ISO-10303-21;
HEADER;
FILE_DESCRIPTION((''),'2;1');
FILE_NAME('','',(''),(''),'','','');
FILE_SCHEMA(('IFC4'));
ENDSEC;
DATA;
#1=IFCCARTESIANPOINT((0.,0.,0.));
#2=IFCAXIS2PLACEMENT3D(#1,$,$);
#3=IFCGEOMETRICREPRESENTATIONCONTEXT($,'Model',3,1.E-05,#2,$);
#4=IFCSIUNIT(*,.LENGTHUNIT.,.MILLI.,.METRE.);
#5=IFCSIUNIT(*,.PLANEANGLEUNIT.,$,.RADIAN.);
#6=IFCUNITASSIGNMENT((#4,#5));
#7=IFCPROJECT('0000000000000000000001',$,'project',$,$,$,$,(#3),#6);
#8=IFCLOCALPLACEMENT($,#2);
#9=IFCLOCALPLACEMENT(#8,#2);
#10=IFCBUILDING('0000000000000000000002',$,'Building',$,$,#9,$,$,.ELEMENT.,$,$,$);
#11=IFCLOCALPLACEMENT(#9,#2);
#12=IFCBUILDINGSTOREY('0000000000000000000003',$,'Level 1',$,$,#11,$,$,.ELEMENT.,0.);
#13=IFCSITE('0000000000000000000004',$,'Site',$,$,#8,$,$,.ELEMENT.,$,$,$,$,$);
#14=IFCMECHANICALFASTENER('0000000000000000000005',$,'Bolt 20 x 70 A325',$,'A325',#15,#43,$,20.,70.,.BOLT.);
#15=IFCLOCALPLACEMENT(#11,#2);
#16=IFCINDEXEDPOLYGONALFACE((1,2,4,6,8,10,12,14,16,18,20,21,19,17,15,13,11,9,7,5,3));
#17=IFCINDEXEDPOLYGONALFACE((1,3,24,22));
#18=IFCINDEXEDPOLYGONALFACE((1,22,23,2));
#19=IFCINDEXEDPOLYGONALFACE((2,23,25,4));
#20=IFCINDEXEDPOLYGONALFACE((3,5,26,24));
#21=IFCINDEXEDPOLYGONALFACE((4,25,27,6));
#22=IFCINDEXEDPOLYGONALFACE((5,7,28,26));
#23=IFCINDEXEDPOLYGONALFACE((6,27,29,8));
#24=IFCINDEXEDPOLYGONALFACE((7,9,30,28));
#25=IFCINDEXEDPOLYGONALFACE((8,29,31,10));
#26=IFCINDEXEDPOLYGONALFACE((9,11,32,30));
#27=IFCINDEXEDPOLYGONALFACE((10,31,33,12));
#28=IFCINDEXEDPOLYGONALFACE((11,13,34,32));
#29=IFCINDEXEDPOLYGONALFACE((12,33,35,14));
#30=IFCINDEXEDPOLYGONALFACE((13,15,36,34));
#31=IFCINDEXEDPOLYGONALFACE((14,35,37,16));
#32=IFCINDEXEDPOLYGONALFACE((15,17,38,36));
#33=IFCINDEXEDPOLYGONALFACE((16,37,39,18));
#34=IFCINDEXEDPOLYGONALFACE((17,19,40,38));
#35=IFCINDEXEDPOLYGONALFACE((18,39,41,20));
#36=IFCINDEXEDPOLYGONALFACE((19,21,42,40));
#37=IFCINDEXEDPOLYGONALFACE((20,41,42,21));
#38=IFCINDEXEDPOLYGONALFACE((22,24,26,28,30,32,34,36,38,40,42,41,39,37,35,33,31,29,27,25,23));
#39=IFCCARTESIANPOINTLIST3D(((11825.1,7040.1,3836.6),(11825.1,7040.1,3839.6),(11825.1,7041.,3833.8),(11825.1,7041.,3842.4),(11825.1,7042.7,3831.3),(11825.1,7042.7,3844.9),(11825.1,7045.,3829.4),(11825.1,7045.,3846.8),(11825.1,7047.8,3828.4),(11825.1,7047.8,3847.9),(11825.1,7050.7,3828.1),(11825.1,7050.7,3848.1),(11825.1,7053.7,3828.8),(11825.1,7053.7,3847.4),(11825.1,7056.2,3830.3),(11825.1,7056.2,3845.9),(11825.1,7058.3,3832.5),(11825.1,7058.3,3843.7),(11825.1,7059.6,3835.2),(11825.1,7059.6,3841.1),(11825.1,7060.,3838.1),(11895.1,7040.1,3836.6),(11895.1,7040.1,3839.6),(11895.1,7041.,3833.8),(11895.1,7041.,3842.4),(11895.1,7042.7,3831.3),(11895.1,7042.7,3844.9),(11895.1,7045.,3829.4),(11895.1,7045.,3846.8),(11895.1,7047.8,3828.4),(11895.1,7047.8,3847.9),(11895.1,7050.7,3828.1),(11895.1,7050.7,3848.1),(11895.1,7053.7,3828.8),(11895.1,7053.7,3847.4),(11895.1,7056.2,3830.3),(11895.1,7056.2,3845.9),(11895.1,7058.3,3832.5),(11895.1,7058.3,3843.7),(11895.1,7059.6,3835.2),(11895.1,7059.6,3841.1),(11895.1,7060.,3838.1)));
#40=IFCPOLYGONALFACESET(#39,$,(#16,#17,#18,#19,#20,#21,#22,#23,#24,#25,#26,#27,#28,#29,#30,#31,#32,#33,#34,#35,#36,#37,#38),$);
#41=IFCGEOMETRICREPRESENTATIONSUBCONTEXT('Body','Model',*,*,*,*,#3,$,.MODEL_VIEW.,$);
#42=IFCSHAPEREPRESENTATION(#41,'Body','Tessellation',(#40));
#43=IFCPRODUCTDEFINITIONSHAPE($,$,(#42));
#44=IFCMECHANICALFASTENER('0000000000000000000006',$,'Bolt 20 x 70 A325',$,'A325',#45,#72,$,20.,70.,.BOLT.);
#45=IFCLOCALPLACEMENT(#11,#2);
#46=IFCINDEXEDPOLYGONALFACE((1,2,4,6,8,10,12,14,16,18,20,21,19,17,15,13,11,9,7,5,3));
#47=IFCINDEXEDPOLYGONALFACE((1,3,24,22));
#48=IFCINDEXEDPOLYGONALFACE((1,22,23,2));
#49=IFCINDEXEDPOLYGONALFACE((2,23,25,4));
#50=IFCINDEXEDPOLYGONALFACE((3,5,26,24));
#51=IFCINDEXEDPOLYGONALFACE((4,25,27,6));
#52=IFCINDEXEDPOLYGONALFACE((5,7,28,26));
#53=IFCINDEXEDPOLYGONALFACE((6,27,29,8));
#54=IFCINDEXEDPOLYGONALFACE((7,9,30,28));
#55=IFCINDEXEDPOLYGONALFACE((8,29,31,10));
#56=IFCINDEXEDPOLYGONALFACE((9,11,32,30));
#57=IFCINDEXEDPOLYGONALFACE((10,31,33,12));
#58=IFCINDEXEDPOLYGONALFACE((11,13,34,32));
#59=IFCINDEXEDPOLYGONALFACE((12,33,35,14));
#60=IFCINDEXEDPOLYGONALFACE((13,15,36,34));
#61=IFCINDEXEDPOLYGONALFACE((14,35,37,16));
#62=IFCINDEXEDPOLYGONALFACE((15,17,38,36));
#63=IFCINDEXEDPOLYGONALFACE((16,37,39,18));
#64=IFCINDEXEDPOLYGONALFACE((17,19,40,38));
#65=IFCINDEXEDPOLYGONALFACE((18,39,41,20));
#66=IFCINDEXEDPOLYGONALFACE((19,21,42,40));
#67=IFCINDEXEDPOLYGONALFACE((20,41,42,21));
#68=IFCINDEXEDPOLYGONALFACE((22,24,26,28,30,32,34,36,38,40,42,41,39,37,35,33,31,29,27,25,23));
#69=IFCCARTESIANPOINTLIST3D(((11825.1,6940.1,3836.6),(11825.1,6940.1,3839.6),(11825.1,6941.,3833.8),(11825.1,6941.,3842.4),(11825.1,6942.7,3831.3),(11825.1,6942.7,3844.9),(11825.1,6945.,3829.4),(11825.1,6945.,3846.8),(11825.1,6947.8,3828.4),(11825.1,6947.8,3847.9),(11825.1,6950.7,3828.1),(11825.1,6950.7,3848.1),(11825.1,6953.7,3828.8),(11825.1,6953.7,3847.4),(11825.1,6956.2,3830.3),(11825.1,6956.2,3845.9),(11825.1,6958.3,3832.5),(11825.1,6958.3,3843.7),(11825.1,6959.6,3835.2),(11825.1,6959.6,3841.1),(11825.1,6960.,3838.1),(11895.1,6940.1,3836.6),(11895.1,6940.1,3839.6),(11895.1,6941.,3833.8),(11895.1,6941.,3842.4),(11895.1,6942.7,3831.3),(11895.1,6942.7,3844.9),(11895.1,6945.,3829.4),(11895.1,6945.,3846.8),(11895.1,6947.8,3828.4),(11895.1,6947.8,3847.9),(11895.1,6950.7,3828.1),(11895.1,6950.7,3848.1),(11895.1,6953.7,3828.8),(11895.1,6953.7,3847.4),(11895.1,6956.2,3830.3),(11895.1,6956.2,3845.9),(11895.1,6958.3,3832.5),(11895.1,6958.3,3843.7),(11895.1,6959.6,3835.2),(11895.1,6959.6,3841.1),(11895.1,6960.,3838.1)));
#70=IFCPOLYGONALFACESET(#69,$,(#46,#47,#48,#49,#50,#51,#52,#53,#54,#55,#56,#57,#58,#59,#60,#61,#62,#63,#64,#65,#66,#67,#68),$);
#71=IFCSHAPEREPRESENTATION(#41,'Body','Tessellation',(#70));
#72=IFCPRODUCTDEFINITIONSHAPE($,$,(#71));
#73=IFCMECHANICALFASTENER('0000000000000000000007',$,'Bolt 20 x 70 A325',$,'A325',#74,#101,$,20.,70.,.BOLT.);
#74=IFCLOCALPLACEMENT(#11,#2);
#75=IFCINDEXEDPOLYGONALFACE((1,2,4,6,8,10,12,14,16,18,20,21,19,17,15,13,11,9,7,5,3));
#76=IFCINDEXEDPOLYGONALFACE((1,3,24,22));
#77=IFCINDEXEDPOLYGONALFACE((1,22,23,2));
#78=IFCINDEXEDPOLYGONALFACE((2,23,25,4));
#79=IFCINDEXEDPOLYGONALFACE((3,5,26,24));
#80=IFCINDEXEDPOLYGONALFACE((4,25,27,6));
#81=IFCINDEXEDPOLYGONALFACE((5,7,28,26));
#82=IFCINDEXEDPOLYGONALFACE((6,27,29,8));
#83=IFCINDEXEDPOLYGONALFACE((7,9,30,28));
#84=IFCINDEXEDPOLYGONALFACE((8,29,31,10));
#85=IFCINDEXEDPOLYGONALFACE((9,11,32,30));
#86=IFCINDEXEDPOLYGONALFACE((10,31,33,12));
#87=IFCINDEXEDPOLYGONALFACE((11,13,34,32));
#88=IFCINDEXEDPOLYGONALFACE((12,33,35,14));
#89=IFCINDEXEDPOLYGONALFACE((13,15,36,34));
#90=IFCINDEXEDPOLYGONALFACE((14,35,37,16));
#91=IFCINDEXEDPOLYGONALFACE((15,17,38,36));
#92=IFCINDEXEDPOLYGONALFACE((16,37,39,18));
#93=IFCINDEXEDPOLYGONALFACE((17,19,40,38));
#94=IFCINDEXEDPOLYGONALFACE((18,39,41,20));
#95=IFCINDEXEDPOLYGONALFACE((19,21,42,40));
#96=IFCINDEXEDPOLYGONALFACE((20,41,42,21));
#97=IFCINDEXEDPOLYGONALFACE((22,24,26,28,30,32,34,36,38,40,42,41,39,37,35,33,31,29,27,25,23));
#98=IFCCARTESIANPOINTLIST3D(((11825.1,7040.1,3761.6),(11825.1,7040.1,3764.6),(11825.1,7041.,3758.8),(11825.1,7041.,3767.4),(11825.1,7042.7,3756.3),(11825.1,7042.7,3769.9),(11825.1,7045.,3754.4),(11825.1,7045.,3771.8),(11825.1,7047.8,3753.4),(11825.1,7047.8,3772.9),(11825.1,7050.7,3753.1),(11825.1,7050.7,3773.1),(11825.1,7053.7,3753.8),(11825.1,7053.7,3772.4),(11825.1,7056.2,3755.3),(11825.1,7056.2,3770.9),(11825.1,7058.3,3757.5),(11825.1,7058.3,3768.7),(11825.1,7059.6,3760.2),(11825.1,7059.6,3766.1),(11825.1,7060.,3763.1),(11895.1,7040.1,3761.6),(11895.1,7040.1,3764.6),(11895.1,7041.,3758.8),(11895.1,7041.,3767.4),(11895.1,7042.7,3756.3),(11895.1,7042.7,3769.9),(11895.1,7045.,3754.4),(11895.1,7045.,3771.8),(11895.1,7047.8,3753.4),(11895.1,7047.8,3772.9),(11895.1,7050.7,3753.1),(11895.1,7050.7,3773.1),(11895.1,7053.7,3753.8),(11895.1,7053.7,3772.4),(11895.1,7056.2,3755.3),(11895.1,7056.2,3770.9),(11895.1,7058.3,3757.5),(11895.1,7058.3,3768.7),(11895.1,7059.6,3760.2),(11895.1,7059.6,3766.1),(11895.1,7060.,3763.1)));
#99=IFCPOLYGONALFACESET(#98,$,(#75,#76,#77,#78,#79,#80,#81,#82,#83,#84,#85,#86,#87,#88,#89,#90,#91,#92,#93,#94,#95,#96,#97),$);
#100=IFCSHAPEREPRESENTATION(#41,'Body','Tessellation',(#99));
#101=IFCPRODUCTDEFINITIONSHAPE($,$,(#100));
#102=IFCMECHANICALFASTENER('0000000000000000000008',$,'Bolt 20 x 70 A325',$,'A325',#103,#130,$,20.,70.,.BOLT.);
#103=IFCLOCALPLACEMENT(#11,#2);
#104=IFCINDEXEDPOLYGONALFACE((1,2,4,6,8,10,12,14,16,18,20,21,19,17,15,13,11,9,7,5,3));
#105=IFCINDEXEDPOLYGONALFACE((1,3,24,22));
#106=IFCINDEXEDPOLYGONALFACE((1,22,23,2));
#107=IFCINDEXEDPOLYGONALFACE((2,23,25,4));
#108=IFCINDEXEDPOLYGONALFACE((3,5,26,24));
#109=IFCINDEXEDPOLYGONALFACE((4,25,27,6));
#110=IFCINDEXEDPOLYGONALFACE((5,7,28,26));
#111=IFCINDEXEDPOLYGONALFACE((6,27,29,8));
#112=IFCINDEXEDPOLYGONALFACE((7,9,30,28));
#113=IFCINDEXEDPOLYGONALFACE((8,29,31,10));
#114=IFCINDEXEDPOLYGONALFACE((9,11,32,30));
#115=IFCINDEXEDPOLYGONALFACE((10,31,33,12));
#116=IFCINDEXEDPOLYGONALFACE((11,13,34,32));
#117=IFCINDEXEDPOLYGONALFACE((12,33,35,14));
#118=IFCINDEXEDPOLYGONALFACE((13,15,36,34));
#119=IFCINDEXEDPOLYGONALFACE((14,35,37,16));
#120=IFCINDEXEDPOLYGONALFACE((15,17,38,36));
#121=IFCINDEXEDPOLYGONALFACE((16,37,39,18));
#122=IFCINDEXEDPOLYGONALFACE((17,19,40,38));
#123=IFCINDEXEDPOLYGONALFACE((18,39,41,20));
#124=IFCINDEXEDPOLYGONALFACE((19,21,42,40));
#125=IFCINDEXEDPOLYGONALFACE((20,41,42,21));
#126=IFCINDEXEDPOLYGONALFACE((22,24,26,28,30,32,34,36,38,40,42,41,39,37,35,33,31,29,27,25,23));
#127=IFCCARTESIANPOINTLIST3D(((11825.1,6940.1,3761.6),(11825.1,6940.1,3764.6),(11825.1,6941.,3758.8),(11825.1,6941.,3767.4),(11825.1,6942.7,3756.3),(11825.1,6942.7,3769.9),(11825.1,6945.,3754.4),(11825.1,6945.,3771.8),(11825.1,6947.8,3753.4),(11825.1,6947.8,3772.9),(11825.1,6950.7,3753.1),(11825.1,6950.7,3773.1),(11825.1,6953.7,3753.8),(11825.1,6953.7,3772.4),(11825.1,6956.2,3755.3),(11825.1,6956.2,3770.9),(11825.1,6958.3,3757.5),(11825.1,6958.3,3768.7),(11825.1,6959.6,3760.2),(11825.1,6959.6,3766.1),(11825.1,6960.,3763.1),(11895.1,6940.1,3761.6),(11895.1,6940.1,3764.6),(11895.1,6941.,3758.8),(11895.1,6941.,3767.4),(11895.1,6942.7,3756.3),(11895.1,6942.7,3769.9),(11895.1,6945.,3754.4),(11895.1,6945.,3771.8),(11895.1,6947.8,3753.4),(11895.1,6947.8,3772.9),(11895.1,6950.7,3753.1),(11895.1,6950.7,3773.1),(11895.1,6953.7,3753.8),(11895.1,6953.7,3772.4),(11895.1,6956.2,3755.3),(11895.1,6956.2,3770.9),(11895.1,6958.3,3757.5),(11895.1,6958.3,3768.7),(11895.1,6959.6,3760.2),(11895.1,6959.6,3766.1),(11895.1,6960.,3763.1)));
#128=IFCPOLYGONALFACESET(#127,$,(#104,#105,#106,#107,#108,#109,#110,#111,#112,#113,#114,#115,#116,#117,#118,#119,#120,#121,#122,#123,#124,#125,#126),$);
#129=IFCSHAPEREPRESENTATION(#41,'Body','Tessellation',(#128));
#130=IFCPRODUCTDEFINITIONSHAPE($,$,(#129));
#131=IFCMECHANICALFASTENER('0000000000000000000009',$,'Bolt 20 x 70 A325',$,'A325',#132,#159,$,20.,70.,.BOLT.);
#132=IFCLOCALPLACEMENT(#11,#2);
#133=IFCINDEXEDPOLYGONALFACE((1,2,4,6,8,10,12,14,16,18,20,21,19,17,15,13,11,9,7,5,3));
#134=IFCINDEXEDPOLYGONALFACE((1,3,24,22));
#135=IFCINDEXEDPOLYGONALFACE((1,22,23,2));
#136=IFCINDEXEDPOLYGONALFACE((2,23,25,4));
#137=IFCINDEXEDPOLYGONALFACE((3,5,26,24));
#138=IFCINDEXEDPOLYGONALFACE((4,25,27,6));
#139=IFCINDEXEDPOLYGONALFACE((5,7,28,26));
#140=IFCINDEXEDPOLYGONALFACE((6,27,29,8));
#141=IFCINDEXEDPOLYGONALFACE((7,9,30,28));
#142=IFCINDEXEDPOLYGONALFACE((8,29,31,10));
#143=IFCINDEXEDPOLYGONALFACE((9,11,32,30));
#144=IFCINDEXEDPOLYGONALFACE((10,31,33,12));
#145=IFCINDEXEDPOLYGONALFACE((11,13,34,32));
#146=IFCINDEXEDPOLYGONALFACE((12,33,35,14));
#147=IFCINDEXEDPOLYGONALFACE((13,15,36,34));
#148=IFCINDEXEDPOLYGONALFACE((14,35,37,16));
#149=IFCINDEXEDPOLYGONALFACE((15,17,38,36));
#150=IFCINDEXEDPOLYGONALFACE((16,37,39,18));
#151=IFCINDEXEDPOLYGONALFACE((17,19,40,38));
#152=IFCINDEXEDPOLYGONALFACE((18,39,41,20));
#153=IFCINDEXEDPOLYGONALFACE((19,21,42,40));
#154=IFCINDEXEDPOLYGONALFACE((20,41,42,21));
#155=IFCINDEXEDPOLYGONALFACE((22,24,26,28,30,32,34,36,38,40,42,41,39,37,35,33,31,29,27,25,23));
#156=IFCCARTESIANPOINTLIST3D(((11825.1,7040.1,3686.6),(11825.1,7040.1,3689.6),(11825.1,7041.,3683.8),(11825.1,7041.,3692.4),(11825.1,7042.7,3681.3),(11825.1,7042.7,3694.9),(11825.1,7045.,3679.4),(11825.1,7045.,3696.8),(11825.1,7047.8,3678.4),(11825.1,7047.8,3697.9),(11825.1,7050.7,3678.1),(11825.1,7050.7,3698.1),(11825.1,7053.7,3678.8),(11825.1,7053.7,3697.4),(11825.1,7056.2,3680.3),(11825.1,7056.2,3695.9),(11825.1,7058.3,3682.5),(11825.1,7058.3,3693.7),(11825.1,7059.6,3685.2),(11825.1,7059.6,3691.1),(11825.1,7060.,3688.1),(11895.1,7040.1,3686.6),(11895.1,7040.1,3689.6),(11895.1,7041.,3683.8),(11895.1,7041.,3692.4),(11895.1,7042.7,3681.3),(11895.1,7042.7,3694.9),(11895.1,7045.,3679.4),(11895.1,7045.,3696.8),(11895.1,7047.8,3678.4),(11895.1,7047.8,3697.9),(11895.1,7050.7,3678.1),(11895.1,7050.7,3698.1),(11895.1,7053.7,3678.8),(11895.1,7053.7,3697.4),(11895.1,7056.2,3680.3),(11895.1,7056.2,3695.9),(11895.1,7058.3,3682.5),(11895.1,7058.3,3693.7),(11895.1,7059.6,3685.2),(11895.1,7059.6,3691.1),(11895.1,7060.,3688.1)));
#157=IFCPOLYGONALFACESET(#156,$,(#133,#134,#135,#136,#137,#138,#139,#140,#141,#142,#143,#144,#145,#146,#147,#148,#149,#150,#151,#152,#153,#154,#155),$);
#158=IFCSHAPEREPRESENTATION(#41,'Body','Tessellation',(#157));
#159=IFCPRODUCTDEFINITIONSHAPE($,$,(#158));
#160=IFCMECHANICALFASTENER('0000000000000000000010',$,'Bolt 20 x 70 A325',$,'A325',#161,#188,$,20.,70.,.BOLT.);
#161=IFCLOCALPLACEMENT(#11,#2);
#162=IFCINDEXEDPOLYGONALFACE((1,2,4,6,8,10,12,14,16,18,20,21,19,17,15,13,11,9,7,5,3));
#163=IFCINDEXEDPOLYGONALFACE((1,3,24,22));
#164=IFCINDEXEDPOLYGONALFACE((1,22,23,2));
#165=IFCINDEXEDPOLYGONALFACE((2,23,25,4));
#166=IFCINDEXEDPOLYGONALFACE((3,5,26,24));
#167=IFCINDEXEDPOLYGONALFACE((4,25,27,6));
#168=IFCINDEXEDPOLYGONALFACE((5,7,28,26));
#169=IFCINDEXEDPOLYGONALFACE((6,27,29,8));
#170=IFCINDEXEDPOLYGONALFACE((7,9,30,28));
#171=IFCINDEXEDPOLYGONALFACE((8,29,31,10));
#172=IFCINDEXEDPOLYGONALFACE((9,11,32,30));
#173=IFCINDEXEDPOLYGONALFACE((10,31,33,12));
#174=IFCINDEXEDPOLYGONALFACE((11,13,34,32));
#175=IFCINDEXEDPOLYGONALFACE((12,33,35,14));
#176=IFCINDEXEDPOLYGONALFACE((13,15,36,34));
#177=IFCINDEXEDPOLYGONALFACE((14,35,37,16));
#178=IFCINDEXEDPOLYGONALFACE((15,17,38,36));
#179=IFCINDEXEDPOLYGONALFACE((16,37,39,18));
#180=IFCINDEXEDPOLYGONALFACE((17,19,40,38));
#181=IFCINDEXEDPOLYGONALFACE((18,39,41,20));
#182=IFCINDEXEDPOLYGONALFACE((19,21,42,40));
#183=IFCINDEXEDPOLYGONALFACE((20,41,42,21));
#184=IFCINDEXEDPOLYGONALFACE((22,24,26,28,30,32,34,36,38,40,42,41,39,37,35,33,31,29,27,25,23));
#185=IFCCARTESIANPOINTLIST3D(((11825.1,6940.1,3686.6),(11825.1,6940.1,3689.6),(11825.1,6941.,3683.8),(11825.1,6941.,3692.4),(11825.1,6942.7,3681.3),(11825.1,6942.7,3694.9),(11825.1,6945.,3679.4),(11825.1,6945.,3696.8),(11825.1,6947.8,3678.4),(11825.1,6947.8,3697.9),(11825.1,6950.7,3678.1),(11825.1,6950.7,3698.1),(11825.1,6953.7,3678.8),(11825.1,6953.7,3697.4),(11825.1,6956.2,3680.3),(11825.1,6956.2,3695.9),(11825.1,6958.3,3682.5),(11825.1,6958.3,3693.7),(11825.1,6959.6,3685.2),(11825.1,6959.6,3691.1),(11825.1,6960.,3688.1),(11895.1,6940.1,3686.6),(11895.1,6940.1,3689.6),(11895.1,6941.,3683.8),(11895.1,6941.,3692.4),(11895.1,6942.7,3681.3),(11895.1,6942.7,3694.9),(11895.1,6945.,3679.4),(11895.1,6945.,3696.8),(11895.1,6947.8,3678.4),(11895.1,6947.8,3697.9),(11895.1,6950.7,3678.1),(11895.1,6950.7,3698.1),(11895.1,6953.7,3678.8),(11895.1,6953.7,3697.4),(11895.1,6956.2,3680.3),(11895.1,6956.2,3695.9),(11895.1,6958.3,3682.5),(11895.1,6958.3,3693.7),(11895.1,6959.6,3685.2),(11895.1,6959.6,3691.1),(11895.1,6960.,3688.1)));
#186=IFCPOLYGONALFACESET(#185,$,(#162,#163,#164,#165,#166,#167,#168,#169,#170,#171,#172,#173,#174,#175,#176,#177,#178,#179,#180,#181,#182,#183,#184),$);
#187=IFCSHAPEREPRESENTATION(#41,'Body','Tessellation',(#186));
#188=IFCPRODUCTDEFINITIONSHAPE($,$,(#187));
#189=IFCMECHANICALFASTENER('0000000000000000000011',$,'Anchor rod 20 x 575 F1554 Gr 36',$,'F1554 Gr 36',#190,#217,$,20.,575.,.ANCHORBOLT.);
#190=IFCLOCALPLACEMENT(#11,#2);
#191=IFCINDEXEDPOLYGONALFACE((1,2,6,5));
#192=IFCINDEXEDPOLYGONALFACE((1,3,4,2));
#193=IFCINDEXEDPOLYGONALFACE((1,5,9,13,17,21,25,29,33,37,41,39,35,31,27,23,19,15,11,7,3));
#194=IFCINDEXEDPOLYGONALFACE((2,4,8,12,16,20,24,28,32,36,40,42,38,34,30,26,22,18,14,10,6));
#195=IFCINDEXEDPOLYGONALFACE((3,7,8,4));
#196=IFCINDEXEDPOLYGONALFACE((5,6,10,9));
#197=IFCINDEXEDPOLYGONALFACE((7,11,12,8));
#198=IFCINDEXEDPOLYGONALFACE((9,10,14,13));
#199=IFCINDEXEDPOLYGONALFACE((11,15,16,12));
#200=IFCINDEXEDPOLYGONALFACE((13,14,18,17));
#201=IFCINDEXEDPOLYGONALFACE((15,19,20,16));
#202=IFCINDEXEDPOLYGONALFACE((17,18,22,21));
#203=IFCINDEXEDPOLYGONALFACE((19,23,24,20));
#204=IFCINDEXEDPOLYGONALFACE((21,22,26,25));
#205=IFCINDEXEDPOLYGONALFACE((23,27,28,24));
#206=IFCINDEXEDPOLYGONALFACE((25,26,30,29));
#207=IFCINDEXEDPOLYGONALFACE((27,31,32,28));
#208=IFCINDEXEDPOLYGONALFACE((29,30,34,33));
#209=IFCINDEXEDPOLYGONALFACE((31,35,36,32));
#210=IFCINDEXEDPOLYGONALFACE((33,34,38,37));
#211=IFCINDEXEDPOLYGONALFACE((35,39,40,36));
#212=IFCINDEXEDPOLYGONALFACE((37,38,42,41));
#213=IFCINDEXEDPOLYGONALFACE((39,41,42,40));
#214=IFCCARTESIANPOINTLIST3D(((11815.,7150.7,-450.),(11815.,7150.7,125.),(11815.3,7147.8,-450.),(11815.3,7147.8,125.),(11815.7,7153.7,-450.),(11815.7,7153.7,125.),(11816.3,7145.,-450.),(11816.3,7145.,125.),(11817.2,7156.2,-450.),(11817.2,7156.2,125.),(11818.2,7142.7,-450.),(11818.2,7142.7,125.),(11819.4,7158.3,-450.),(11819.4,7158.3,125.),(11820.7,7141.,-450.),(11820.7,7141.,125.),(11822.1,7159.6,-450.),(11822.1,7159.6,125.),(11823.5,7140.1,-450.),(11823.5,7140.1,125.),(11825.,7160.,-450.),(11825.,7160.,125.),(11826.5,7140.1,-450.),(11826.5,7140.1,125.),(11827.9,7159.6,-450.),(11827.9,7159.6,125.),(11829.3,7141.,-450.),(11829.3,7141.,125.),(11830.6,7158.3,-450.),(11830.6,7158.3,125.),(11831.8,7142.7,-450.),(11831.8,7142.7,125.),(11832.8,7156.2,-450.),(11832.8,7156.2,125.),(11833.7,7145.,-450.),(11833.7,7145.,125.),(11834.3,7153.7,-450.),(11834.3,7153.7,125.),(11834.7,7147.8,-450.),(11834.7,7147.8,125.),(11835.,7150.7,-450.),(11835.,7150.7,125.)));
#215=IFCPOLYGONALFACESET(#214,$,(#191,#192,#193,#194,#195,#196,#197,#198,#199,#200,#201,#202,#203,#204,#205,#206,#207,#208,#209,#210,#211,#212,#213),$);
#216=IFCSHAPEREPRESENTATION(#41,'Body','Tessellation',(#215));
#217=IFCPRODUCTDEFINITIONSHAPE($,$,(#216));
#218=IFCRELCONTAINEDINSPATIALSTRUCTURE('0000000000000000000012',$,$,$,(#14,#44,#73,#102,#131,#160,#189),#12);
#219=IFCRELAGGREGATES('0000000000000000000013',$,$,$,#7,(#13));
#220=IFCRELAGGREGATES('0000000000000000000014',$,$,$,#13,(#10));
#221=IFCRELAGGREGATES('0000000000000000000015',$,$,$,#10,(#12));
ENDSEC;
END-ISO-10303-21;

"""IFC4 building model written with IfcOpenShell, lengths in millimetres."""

from ifc_helpers import new_model, si_unit, frame, origin, origin_2d, place, context, subcontext, project, spatial, circle, extrude, element, save


model = new_model("IFC4")

# Units and contexts
model_context = context("Model", 3, precision=1e-05, world=origin())
body_context = subcontext(model_context, "Body", "Model", "MODEL_VIEW")
ifc_project = project(units=[si_unit("LENGTHUNIT", "METRE", prefix="MILLI"), si_unit("PLANEANGLEUNIT", "RADIAN")], contexts=[model_context])

# Site, building, storey
site_placement = place(None, origin())
site = spatial("IfcSite", under=ifc_project, at=site_placement, Name="Site", CompositionType="ELEMENT")
building_placement = place(site_placement, origin())
building = spatial("IfcBuilding", under=site, at=building_placement, Name="Building", CompositionType="ELEMENT")
storey_placement = place(building_placement, origin())
storey = spatial("IfcBuildingStorey", under=building, at=storey_placement, Name="Level 1", CompositionType="ELEMENT", Elevation=0.0)

# Mechanical fasteners
for number, where, z_axis, x_axis, name in (
    (1, (11825.1, 7050.0, 3838.1), (1.0, 0.0, 0.0), (0.0, 1.0, 0.0), "Bolt 20 x 70 A325"),
    (2, (11825.1, 6950.0, 3838.1), (1.0, 0.0, 0.0), (0.0, 1.0, 0.0), "Bolt 20 x 70 A325"),
    (3, (11825.1, 7050.0, 3763.1), (1.0, 0.0, 0.0), (0.0, 1.0, 0.0), "Bolt 20 x 70 A325"),
    (4, (11825.1, 6950.0, 3763.1), (1.0, 0.0, 0.0), (0.0, 1.0, 0.0), "Bolt 20 x 70 A325"),
    (5, (11825.1, 7050.0, 3688.1), (1.0, 0.0, 0.0), (0.0, 1.0, 0.0), "Bolt 20 x 70 A325"),
    (6, (11825.1, 6950.0, 3688.1), (1.0, 0.0, 0.0), (0.0, 1.0, 0.0), "Bolt 20 x 70 A325"),
):
    element("IfcMechanicalFastener", number, at=place(storey_placement, frame(where, z_axis=z_axis, x_axis=x_axis)), inside=storey, Name=name, ObjectType="A325", NominalDiameter=20.0, NominalLength=70.0, PredefinedType="BOLT", context=body_context, shape_type="SweptSolid", body=[
        extrude(circle(Radius=10.0, at=origin_2d()), origin(), (0.0, 0.0, 1.0), 70.0),
    ])
for number, where, z_axis, x_axis, name in (
    (7, (11825.0, 7150.0, 125.0), (0.0, 0.0, -1.0), (0.0, 1.0, 0.0), "Anchor rod 20 x 575 F1554 Gr 36"),
):
    element("IfcMechanicalFastener", number, at=place(storey_placement, frame(where, z_axis=z_axis, x_axis=x_axis)), inside=storey, Name=name, ObjectType="F1554 Gr 36", NominalDiameter=20.0, NominalLength=575.0, PredefinedType="ANCHORBOLT", context=body_context, shape_type="SweptSolid", body=[
        extrude(circle(Radius=10.0, at=origin_2d()), origin(), (0.0, 0.0, 1.0), 575.0),
    ])

save(model, "model.ifc")
